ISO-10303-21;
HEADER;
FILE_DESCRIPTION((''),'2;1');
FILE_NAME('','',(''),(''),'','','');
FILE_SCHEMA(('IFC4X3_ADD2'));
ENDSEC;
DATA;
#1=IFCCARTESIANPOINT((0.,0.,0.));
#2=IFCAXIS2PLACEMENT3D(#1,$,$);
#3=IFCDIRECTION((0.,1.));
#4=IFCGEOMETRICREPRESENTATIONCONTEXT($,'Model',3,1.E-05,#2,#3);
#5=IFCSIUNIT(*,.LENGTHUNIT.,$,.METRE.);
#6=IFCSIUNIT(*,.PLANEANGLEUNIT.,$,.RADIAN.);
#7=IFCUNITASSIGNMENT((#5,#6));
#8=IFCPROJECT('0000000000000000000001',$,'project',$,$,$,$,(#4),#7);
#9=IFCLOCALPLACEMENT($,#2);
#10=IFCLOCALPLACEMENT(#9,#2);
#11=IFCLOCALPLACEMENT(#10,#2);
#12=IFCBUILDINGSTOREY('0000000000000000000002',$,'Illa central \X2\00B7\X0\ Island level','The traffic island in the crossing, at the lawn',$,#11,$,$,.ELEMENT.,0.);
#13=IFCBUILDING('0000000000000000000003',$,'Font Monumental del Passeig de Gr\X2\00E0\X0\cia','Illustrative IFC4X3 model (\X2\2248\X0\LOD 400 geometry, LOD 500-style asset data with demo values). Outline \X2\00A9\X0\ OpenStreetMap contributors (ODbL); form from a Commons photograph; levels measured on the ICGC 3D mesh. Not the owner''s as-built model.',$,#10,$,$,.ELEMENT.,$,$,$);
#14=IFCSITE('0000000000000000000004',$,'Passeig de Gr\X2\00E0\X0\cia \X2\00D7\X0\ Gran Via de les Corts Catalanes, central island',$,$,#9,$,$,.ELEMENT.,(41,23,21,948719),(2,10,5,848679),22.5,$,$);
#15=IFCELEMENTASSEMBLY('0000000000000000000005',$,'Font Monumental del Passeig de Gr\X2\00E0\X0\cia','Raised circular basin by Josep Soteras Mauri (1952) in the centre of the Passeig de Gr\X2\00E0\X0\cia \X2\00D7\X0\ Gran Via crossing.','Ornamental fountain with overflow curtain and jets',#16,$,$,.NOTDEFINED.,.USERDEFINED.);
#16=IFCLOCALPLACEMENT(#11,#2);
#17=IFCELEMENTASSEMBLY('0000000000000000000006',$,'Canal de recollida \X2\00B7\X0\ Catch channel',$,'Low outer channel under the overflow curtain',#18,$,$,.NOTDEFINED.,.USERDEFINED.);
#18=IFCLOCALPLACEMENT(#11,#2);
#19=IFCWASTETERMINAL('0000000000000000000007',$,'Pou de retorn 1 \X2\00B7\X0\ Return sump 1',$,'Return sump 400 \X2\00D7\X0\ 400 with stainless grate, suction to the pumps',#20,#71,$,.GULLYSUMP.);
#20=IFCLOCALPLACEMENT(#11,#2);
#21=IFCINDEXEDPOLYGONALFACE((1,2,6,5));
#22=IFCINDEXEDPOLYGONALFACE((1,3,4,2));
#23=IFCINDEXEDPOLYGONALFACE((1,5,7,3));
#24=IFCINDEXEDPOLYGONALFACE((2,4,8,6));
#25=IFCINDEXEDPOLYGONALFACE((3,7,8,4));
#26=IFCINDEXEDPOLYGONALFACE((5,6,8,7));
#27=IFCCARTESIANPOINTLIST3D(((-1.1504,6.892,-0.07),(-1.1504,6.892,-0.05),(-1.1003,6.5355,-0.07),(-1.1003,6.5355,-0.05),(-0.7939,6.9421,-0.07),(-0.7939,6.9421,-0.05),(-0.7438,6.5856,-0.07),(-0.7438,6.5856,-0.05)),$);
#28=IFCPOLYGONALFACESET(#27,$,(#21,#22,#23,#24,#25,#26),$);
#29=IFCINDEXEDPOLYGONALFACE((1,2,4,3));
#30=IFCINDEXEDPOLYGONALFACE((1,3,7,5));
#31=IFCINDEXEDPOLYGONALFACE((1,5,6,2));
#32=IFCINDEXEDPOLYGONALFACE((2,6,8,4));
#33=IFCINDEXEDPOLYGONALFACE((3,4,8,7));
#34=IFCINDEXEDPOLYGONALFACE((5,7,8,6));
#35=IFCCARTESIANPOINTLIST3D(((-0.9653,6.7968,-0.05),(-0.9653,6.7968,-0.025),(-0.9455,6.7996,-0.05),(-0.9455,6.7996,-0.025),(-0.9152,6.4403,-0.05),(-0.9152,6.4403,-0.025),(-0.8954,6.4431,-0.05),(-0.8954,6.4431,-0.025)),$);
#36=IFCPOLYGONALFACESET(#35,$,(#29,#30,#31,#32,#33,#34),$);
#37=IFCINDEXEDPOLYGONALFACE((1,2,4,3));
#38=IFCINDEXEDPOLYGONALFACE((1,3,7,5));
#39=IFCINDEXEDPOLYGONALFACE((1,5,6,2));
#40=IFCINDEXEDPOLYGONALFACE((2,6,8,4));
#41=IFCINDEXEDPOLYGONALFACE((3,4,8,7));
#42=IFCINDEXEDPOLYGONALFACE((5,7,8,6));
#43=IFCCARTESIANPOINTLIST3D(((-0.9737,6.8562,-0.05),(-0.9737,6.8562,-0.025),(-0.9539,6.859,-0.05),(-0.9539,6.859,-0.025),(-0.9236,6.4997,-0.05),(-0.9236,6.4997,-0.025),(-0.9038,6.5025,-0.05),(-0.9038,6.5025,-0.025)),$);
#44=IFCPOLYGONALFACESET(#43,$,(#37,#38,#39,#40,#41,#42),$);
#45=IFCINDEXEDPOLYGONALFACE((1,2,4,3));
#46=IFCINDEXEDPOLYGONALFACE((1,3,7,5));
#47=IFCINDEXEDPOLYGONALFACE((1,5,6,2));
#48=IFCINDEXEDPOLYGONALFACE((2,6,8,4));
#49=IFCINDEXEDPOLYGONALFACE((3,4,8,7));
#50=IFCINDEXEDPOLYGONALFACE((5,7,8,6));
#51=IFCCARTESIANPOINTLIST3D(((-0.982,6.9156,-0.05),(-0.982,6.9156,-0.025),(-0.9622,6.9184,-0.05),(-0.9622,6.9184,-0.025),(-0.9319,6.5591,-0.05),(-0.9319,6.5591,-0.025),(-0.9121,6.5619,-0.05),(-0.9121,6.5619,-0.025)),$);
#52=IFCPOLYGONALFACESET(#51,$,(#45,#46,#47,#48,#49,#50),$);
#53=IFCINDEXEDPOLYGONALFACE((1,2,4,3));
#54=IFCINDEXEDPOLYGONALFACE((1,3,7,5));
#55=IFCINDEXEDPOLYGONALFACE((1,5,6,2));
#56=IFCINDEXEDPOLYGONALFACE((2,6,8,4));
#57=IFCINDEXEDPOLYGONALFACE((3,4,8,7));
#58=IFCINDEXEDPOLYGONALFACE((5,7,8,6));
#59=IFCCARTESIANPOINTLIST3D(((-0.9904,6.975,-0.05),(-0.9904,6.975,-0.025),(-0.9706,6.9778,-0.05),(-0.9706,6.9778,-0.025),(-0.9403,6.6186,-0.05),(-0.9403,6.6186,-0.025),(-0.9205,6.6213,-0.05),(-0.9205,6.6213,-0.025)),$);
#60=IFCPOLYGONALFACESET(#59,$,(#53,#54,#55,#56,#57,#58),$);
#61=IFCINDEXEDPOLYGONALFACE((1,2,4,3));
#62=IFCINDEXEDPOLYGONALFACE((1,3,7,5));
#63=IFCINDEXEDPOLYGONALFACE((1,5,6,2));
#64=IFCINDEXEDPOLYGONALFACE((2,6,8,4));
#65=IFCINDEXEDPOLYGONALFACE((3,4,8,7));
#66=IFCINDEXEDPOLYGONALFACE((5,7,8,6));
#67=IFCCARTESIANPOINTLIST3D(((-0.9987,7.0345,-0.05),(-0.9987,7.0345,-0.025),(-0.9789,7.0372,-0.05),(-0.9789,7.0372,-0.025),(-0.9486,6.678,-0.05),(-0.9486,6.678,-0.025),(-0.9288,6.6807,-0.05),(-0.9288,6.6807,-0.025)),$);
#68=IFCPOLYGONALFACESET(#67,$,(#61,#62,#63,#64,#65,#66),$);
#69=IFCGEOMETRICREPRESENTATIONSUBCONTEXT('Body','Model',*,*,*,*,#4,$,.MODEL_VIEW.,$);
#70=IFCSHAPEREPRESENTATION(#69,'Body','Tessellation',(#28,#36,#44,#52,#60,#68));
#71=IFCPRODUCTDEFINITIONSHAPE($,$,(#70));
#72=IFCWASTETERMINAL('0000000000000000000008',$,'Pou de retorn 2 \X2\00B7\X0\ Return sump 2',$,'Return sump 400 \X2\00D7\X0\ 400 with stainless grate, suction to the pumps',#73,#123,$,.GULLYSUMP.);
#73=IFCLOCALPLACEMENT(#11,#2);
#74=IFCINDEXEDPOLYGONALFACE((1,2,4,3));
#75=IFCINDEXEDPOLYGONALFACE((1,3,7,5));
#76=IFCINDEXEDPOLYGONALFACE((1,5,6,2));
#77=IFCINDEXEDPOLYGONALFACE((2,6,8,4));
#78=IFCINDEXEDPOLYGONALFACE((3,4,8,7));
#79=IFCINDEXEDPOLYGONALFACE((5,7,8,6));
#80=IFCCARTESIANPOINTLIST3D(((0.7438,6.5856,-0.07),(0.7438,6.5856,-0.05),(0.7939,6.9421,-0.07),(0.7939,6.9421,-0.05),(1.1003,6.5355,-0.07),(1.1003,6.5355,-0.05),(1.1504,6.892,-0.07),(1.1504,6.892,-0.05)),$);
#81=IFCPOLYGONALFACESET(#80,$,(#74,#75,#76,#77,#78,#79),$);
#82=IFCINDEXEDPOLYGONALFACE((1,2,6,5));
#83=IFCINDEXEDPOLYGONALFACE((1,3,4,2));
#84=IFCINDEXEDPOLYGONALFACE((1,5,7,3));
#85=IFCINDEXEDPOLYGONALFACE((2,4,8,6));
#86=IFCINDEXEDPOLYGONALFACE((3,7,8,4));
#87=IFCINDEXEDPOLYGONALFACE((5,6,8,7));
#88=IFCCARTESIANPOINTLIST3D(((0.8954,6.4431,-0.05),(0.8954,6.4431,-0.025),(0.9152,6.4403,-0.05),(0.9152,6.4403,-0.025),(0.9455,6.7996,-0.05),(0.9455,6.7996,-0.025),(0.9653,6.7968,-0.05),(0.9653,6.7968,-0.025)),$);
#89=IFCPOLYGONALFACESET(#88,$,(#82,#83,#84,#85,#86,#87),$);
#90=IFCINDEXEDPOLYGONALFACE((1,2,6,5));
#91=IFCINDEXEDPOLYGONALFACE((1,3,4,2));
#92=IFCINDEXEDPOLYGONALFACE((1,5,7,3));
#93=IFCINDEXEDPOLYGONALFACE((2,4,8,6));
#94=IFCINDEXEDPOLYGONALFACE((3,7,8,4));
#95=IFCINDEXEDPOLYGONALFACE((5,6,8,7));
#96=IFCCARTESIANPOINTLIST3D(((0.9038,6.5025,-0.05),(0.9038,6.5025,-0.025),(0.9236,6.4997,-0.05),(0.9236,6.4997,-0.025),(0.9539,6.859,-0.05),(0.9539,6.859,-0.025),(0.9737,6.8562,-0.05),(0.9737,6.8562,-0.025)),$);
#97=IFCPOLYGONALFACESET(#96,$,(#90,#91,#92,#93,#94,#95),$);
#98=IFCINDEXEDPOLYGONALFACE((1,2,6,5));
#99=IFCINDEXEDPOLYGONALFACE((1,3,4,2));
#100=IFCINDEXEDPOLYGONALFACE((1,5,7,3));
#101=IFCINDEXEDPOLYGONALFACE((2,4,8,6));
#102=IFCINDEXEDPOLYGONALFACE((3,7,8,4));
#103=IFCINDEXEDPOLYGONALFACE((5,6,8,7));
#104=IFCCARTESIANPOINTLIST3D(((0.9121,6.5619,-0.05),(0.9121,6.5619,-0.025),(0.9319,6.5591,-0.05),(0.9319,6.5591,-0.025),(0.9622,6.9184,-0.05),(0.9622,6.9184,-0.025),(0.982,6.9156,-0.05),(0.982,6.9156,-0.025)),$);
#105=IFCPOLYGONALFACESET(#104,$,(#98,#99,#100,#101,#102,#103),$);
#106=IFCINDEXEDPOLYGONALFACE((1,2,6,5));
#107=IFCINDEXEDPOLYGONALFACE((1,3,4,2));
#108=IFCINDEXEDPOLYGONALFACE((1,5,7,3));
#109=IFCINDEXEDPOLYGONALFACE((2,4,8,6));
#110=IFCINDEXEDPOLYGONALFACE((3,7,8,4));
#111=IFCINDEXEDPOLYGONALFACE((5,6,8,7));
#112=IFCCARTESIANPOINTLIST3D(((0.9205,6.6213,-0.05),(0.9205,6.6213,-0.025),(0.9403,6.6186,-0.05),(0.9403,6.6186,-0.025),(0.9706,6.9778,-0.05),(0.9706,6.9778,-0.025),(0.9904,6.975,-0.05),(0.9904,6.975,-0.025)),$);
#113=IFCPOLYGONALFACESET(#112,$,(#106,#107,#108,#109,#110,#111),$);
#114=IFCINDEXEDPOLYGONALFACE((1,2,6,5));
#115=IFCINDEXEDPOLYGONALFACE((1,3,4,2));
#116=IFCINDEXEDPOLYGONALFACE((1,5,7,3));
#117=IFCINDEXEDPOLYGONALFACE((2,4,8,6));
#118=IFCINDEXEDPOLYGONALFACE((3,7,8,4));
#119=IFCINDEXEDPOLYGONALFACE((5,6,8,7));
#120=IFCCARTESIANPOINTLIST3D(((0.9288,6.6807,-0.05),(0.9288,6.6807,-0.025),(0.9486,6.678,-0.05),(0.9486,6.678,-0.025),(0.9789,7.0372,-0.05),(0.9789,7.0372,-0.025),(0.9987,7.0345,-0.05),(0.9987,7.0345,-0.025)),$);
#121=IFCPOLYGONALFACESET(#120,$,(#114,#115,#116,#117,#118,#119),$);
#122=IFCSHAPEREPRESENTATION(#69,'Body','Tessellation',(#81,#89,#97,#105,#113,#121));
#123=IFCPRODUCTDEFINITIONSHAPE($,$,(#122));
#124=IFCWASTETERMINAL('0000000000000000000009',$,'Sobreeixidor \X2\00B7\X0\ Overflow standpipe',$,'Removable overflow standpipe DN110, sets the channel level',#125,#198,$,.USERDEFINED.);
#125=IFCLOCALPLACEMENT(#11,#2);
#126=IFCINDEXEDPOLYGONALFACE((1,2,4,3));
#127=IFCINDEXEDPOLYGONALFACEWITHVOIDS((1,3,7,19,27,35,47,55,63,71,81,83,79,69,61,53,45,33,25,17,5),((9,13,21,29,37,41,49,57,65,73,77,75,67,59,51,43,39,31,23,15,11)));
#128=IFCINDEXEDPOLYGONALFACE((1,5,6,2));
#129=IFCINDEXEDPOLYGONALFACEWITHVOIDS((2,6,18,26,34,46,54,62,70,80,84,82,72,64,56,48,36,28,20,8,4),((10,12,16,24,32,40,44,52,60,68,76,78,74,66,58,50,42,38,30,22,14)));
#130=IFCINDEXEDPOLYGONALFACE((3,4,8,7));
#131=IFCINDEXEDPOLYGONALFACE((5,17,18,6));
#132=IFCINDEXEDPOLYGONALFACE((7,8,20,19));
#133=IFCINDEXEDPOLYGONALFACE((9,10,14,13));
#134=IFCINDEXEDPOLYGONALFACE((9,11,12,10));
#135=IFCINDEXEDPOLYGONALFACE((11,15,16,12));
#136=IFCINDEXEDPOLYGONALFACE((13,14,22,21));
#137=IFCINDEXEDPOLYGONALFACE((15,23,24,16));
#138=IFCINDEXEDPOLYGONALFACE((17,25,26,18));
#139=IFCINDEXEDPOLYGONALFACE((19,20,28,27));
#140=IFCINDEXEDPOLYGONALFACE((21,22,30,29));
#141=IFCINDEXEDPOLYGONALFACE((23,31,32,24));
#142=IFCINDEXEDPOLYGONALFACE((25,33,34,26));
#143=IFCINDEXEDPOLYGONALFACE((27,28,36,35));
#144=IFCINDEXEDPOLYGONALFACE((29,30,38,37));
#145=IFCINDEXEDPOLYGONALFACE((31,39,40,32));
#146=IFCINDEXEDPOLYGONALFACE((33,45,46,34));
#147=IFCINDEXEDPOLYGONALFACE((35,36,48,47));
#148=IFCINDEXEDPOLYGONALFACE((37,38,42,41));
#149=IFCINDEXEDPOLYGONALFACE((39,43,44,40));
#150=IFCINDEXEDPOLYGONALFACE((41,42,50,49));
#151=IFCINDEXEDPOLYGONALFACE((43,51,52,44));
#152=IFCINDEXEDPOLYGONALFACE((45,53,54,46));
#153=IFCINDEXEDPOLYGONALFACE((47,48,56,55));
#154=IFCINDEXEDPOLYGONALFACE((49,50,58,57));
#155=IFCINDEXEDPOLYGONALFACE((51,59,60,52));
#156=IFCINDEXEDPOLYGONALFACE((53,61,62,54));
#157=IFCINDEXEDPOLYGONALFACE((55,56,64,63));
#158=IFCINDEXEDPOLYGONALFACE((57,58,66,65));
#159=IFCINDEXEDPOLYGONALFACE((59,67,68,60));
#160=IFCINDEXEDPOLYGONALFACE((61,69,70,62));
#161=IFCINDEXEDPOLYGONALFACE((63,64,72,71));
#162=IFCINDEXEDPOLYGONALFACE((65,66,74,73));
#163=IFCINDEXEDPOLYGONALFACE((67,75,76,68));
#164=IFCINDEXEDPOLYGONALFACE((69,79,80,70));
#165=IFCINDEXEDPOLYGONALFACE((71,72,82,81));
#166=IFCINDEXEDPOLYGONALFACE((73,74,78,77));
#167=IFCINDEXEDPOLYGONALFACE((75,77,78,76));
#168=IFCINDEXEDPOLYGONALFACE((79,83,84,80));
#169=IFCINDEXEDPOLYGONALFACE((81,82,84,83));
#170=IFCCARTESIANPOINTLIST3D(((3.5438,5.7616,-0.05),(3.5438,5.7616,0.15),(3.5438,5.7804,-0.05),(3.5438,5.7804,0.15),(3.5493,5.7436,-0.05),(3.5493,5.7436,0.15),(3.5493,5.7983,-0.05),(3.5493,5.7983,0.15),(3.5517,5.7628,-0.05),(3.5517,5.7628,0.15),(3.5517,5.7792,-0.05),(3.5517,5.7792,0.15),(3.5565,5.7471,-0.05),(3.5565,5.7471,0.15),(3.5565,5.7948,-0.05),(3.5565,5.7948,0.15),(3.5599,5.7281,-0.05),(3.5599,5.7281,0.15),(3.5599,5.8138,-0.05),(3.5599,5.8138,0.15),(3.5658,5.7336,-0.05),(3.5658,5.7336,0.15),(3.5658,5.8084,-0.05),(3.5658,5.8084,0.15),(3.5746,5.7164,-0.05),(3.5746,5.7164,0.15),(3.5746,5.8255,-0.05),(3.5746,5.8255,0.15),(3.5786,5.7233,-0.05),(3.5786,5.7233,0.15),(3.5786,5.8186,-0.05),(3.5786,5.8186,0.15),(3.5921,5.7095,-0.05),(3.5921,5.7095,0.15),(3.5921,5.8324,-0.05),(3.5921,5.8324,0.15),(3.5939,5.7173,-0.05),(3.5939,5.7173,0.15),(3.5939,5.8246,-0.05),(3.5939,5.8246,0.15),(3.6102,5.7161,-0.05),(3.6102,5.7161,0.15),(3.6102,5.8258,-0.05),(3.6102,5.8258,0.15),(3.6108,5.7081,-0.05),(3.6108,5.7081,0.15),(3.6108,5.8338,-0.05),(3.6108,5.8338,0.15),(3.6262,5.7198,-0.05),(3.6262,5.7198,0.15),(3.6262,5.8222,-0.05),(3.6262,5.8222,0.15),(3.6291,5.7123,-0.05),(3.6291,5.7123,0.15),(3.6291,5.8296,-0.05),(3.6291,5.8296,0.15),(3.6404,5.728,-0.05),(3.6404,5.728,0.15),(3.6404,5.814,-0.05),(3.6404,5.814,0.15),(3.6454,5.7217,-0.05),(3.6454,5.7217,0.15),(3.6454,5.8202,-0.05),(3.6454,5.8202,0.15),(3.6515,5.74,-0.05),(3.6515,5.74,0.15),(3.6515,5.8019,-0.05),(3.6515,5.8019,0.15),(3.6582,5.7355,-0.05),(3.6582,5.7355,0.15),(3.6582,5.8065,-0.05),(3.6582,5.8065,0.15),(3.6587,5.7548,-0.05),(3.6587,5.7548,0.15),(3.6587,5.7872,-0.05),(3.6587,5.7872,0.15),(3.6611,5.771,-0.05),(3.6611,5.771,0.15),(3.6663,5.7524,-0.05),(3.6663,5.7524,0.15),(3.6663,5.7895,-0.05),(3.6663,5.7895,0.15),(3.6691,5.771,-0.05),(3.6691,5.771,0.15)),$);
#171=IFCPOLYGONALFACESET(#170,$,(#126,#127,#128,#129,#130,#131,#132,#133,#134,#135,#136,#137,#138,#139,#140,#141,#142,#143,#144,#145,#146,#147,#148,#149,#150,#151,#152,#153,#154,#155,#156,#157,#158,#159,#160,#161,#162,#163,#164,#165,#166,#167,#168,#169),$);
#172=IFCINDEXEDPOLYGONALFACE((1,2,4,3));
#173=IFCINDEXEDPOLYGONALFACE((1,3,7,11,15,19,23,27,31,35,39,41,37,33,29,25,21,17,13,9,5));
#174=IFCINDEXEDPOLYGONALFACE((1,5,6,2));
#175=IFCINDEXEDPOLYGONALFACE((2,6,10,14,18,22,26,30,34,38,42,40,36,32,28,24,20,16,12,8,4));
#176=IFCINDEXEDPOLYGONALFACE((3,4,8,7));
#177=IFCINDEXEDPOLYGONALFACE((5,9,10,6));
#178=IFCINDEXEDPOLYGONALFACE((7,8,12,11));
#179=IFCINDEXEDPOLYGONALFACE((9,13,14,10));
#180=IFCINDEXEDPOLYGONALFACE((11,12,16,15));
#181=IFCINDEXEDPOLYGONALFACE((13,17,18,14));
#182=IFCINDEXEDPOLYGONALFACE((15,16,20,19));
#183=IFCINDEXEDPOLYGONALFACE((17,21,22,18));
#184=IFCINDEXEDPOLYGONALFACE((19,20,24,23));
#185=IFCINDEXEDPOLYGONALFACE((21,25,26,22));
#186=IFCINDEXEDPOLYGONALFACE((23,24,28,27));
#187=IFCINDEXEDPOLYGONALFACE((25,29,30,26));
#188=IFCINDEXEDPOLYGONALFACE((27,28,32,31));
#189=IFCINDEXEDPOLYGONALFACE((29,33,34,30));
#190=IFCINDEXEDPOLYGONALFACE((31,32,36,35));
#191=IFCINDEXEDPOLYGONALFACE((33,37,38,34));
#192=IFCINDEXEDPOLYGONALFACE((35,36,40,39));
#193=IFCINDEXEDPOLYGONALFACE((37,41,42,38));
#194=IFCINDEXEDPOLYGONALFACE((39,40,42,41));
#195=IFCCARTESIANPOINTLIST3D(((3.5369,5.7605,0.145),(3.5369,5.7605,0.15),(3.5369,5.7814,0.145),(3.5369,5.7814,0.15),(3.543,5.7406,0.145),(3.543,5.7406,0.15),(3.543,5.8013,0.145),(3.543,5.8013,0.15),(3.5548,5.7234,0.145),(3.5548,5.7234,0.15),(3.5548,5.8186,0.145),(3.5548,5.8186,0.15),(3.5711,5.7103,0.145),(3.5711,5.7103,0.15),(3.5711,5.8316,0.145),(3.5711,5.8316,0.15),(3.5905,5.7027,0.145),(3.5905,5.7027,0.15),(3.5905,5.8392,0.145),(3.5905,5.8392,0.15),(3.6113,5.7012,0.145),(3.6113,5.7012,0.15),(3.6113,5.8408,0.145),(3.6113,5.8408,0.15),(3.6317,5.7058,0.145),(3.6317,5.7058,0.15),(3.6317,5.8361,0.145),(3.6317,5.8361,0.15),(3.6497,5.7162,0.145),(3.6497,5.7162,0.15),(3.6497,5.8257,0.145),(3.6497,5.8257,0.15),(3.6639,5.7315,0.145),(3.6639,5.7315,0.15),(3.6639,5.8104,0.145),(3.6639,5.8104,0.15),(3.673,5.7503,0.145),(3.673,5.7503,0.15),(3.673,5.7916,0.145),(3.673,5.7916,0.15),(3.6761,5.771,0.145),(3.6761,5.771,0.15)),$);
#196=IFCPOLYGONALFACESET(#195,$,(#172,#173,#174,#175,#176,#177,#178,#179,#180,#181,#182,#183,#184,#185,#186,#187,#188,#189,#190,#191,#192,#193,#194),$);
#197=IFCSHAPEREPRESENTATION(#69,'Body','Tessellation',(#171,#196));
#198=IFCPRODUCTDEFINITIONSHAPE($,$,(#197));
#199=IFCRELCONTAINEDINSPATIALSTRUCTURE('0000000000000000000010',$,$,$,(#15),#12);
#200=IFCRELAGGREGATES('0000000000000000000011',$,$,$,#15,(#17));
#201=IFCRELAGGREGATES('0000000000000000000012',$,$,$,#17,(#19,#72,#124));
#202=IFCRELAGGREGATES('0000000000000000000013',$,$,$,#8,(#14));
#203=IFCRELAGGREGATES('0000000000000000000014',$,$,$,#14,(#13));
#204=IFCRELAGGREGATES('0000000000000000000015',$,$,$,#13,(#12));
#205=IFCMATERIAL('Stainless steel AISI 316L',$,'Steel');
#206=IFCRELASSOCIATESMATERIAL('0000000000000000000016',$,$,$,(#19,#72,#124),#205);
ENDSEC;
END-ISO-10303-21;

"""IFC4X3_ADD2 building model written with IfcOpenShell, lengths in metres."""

from ifc_helpers import new_model, si_unit, direction, frame, frame_2d, origin, origin_2d_with_axis, place, context, subcontext, project, spatial, rectangle, circle, hollow_circle, extrude, material, element, aggregate, save


model = new_model("IFC4X3_ADD2")

# Units and contexts
model_context = context("Model", 3, precision=1e-05, world=origin(), true_north=direction((0.0, 1.0)))
body_context = subcontext(model_context, "Body", "Model", "MODEL_VIEW")
ifc_project = project(units=[si_unit("LENGTHUNIT", "METRE"), si_unit("PLANEANGLEUNIT", "RADIAN")], contexts=[model_context])

# Site, building, storey
site_placement = place(None, origin())
site = spatial("IfcSite", under=ifc_project, at=site_placement, Name="Passeig de Gràcia × Gran Via de les Corts Catalanes, central island", CompositionType="ELEMENT", RefLatitude=(41, 23, 21, 948719), RefLongitude=(2, 10, 5, 848679), RefElevation=22.5)
building_placement = place(site_placement, origin())
building = spatial("IfcBuilding", under=site, at=building_placement, Name="Font Monumental del Passeig de Gràcia", Description="Illustrative IFC4X3 model (≈LOD 400 geometry, LOD 500-style asset data with demo values). Outline © OpenStreetMap contributors (ODbL); form from a Commons photograph; levels measured on the ICGC 3D mesh. Not the owner's as-built model.", CompositionType="ELEMENT")
storey_placement = place(building_placement, origin())
storey = spatial("IfcBuildingStorey", under=building, at=storey_placement, Name="Illa central · Island level", Description="The traffic island in the crossing, at the lawn", CompositionType="ELEMENT", Elevation=0.0)

# Element assemblies, waste terminals
assembly_1_placement = place(building_placement, origin())
assembly_1 = element("IfcElementAssembly", 1, at=assembly_1_placement, inside=storey, Name="Font Monumental del Passeig de Gràcia", Description="Raised circular basin by Josep Soteras Mauri (1952) in the centre of the Passeig de Gràcia × Gran Via crossing.", ObjectType="Ornamental fountain with overflow curtain and jets", AssemblyPlace="NOTDEFINED", PredefinedType="USERDEFINED")
ifc_material_1 = material(Name="Stainless steel AISI 316L", Category="Steel")
assembly_2_placement = place(building_placement, origin())
assembly_2 = element("IfcElementAssembly", 2, at=assembly_2_placement, Name="Canal de recollida · Catch channel", ObjectType="Low outer channel under the overflow curtain", AssemblyPlace="NOTDEFINED", PredefinedType="USERDEFINED")
waste_terminal_1_placement = place(building_placement, origin())
waste_terminal_1 = element("IfcWasteTerminal", 3, at=waste_terminal_1_placement, material=ifc_material_1, Name="Pou de retorn 1 · Return sump 1", ObjectType="Return sump 400 × 400 with stainless grate, suction to the pumps", PredefinedType="GULLYSUMP", context=body_context, shape_type="SweptSolid", body=[
    extrude(rectangle(XDim=0.36, YDim=0.36, at=frame_2d((0.0, 0.0), x_axis=(-0.139173, 0.990268))), frame((-0.9471, 6.7388, -0.07)), (0.0, 0.0, 1.0), 0.02),
    extrude(rectangle(XDim=0.36, YDim=0.02, at=frame_2d((0.0, 0.0), x_axis=(-0.139173, 0.990268))), frame((-0.9304, 6.6199, -0.05)), (0.0, 0.0, 1.0), 0.025),
    extrude(rectangle(XDim=0.36, YDim=0.02, at=frame_2d((0.0, 0.0), x_axis=(-0.139173, 0.990268))), frame((-0.9387, 6.6794, -0.05)), (0.0, 0.0, 1.0), 0.025),
    extrude(rectangle(XDim=0.36, YDim=0.02, at=frame_2d((0.0, 0.0), x_axis=(-0.139173, 0.990268))), frame((-0.9471, 6.7388, -0.05)), (0.0, 0.0, 1.0), 0.025),
    extrude(rectangle(XDim=0.36, YDim=0.02, at=frame_2d((0.0, 0.0), x_axis=(-0.139173, 0.990268))), frame((-0.9554, 6.7982, -0.05)), (0.0, 0.0, 1.0), 0.025),
    extrude(rectangle(XDim=0.36, YDim=0.02, at=frame_2d((0.0, 0.0), x_axis=(-0.139173, 0.990268))), frame((-0.9638, 6.8576, -0.05)), (0.0, 0.0, 1.0), 0.025),
])
waste_terminal_2_placement = place(building_placement, origin())
waste_terminal_2 = element("IfcWasteTerminal", 4, at=waste_terminal_2_placement, material=ifc_material_1, Name="Pou de retorn 2 · Return sump 2", ObjectType="Return sump 400 × 400 with stainless grate, suction to the pumps", PredefinedType="GULLYSUMP", context=body_context, shape_type="SweptSolid", body=[
    extrude(rectangle(XDim=0.36, YDim=0.36, at=frame_2d((0.0, 0.0), x_axis=(0.139173, 0.990268))), frame((0.9471, 6.7388, -0.07)), (0.0, 0.0, 1.0), 0.02),
    extrude(rectangle(XDim=0.36, YDim=0.02, at=frame_2d((0.0, 0.0), x_axis=(0.139173, 0.990268))), frame((0.9304, 6.6199, -0.05)), (0.0, 0.0, 1.0), 0.025),
    extrude(rectangle(XDim=0.36, YDim=0.02, at=frame_2d((0.0, 0.0), x_axis=(0.139173, 0.990268))), frame((0.9387, 6.6794, -0.05)), (0.0, 0.0, 1.0), 0.025),
    extrude(rectangle(XDim=0.36, YDim=0.02, at=frame_2d((0.0, 0.0), x_axis=(0.139173, 0.990268))), frame((0.9471, 6.7388, -0.05)), (0.0, 0.0, 1.0), 0.025),
    extrude(rectangle(XDim=0.36, YDim=0.02, at=frame_2d((0.0, 0.0), x_axis=(0.139173, 0.990268))), frame((0.9554, 6.7982, -0.05)), (0.0, 0.0, 1.0), 0.025),
    extrude(rectangle(XDim=0.36, YDim=0.02, at=frame_2d((0.0, 0.0), x_axis=(0.139173, 0.990268))), frame((0.9638, 6.8576, -0.05)), (0.0, 0.0, 1.0), 0.025),
])
waste_terminal_3_placement = place(building_placement, origin())
waste_terminal_3 = element("IfcWasteTerminal", 5, at=waste_terminal_3_placement, material=ifc_material_1, Name="Sobreeixidor · Overflow standpipe", ObjectType="Removable overflow standpipe DN110, sets the channel level", PredefinedType="USERDEFINED", context=body_context, shape_type="SweptSolid", body=[
    extrude(hollow_circle(Radius=0.063, WallThickness=0.008, at=origin_2d_with_axis()), frame((3.6061, 5.771, -0.05)), (0.0, 0.0, 1.0), 0.2),
    extrude(circle(Radius=0.07, at=origin_2d_with_axis()), frame((3.6061, 5.771, 0.145)), (0.0, 0.0, 1.0), 0.005),
])
aggregate(assembly_1, [assembly_2])
aggregate(assembly_2, [waste_terminal_1, waste_terminal_2, waste_terminal_3])

save(model, "model.ifc")
